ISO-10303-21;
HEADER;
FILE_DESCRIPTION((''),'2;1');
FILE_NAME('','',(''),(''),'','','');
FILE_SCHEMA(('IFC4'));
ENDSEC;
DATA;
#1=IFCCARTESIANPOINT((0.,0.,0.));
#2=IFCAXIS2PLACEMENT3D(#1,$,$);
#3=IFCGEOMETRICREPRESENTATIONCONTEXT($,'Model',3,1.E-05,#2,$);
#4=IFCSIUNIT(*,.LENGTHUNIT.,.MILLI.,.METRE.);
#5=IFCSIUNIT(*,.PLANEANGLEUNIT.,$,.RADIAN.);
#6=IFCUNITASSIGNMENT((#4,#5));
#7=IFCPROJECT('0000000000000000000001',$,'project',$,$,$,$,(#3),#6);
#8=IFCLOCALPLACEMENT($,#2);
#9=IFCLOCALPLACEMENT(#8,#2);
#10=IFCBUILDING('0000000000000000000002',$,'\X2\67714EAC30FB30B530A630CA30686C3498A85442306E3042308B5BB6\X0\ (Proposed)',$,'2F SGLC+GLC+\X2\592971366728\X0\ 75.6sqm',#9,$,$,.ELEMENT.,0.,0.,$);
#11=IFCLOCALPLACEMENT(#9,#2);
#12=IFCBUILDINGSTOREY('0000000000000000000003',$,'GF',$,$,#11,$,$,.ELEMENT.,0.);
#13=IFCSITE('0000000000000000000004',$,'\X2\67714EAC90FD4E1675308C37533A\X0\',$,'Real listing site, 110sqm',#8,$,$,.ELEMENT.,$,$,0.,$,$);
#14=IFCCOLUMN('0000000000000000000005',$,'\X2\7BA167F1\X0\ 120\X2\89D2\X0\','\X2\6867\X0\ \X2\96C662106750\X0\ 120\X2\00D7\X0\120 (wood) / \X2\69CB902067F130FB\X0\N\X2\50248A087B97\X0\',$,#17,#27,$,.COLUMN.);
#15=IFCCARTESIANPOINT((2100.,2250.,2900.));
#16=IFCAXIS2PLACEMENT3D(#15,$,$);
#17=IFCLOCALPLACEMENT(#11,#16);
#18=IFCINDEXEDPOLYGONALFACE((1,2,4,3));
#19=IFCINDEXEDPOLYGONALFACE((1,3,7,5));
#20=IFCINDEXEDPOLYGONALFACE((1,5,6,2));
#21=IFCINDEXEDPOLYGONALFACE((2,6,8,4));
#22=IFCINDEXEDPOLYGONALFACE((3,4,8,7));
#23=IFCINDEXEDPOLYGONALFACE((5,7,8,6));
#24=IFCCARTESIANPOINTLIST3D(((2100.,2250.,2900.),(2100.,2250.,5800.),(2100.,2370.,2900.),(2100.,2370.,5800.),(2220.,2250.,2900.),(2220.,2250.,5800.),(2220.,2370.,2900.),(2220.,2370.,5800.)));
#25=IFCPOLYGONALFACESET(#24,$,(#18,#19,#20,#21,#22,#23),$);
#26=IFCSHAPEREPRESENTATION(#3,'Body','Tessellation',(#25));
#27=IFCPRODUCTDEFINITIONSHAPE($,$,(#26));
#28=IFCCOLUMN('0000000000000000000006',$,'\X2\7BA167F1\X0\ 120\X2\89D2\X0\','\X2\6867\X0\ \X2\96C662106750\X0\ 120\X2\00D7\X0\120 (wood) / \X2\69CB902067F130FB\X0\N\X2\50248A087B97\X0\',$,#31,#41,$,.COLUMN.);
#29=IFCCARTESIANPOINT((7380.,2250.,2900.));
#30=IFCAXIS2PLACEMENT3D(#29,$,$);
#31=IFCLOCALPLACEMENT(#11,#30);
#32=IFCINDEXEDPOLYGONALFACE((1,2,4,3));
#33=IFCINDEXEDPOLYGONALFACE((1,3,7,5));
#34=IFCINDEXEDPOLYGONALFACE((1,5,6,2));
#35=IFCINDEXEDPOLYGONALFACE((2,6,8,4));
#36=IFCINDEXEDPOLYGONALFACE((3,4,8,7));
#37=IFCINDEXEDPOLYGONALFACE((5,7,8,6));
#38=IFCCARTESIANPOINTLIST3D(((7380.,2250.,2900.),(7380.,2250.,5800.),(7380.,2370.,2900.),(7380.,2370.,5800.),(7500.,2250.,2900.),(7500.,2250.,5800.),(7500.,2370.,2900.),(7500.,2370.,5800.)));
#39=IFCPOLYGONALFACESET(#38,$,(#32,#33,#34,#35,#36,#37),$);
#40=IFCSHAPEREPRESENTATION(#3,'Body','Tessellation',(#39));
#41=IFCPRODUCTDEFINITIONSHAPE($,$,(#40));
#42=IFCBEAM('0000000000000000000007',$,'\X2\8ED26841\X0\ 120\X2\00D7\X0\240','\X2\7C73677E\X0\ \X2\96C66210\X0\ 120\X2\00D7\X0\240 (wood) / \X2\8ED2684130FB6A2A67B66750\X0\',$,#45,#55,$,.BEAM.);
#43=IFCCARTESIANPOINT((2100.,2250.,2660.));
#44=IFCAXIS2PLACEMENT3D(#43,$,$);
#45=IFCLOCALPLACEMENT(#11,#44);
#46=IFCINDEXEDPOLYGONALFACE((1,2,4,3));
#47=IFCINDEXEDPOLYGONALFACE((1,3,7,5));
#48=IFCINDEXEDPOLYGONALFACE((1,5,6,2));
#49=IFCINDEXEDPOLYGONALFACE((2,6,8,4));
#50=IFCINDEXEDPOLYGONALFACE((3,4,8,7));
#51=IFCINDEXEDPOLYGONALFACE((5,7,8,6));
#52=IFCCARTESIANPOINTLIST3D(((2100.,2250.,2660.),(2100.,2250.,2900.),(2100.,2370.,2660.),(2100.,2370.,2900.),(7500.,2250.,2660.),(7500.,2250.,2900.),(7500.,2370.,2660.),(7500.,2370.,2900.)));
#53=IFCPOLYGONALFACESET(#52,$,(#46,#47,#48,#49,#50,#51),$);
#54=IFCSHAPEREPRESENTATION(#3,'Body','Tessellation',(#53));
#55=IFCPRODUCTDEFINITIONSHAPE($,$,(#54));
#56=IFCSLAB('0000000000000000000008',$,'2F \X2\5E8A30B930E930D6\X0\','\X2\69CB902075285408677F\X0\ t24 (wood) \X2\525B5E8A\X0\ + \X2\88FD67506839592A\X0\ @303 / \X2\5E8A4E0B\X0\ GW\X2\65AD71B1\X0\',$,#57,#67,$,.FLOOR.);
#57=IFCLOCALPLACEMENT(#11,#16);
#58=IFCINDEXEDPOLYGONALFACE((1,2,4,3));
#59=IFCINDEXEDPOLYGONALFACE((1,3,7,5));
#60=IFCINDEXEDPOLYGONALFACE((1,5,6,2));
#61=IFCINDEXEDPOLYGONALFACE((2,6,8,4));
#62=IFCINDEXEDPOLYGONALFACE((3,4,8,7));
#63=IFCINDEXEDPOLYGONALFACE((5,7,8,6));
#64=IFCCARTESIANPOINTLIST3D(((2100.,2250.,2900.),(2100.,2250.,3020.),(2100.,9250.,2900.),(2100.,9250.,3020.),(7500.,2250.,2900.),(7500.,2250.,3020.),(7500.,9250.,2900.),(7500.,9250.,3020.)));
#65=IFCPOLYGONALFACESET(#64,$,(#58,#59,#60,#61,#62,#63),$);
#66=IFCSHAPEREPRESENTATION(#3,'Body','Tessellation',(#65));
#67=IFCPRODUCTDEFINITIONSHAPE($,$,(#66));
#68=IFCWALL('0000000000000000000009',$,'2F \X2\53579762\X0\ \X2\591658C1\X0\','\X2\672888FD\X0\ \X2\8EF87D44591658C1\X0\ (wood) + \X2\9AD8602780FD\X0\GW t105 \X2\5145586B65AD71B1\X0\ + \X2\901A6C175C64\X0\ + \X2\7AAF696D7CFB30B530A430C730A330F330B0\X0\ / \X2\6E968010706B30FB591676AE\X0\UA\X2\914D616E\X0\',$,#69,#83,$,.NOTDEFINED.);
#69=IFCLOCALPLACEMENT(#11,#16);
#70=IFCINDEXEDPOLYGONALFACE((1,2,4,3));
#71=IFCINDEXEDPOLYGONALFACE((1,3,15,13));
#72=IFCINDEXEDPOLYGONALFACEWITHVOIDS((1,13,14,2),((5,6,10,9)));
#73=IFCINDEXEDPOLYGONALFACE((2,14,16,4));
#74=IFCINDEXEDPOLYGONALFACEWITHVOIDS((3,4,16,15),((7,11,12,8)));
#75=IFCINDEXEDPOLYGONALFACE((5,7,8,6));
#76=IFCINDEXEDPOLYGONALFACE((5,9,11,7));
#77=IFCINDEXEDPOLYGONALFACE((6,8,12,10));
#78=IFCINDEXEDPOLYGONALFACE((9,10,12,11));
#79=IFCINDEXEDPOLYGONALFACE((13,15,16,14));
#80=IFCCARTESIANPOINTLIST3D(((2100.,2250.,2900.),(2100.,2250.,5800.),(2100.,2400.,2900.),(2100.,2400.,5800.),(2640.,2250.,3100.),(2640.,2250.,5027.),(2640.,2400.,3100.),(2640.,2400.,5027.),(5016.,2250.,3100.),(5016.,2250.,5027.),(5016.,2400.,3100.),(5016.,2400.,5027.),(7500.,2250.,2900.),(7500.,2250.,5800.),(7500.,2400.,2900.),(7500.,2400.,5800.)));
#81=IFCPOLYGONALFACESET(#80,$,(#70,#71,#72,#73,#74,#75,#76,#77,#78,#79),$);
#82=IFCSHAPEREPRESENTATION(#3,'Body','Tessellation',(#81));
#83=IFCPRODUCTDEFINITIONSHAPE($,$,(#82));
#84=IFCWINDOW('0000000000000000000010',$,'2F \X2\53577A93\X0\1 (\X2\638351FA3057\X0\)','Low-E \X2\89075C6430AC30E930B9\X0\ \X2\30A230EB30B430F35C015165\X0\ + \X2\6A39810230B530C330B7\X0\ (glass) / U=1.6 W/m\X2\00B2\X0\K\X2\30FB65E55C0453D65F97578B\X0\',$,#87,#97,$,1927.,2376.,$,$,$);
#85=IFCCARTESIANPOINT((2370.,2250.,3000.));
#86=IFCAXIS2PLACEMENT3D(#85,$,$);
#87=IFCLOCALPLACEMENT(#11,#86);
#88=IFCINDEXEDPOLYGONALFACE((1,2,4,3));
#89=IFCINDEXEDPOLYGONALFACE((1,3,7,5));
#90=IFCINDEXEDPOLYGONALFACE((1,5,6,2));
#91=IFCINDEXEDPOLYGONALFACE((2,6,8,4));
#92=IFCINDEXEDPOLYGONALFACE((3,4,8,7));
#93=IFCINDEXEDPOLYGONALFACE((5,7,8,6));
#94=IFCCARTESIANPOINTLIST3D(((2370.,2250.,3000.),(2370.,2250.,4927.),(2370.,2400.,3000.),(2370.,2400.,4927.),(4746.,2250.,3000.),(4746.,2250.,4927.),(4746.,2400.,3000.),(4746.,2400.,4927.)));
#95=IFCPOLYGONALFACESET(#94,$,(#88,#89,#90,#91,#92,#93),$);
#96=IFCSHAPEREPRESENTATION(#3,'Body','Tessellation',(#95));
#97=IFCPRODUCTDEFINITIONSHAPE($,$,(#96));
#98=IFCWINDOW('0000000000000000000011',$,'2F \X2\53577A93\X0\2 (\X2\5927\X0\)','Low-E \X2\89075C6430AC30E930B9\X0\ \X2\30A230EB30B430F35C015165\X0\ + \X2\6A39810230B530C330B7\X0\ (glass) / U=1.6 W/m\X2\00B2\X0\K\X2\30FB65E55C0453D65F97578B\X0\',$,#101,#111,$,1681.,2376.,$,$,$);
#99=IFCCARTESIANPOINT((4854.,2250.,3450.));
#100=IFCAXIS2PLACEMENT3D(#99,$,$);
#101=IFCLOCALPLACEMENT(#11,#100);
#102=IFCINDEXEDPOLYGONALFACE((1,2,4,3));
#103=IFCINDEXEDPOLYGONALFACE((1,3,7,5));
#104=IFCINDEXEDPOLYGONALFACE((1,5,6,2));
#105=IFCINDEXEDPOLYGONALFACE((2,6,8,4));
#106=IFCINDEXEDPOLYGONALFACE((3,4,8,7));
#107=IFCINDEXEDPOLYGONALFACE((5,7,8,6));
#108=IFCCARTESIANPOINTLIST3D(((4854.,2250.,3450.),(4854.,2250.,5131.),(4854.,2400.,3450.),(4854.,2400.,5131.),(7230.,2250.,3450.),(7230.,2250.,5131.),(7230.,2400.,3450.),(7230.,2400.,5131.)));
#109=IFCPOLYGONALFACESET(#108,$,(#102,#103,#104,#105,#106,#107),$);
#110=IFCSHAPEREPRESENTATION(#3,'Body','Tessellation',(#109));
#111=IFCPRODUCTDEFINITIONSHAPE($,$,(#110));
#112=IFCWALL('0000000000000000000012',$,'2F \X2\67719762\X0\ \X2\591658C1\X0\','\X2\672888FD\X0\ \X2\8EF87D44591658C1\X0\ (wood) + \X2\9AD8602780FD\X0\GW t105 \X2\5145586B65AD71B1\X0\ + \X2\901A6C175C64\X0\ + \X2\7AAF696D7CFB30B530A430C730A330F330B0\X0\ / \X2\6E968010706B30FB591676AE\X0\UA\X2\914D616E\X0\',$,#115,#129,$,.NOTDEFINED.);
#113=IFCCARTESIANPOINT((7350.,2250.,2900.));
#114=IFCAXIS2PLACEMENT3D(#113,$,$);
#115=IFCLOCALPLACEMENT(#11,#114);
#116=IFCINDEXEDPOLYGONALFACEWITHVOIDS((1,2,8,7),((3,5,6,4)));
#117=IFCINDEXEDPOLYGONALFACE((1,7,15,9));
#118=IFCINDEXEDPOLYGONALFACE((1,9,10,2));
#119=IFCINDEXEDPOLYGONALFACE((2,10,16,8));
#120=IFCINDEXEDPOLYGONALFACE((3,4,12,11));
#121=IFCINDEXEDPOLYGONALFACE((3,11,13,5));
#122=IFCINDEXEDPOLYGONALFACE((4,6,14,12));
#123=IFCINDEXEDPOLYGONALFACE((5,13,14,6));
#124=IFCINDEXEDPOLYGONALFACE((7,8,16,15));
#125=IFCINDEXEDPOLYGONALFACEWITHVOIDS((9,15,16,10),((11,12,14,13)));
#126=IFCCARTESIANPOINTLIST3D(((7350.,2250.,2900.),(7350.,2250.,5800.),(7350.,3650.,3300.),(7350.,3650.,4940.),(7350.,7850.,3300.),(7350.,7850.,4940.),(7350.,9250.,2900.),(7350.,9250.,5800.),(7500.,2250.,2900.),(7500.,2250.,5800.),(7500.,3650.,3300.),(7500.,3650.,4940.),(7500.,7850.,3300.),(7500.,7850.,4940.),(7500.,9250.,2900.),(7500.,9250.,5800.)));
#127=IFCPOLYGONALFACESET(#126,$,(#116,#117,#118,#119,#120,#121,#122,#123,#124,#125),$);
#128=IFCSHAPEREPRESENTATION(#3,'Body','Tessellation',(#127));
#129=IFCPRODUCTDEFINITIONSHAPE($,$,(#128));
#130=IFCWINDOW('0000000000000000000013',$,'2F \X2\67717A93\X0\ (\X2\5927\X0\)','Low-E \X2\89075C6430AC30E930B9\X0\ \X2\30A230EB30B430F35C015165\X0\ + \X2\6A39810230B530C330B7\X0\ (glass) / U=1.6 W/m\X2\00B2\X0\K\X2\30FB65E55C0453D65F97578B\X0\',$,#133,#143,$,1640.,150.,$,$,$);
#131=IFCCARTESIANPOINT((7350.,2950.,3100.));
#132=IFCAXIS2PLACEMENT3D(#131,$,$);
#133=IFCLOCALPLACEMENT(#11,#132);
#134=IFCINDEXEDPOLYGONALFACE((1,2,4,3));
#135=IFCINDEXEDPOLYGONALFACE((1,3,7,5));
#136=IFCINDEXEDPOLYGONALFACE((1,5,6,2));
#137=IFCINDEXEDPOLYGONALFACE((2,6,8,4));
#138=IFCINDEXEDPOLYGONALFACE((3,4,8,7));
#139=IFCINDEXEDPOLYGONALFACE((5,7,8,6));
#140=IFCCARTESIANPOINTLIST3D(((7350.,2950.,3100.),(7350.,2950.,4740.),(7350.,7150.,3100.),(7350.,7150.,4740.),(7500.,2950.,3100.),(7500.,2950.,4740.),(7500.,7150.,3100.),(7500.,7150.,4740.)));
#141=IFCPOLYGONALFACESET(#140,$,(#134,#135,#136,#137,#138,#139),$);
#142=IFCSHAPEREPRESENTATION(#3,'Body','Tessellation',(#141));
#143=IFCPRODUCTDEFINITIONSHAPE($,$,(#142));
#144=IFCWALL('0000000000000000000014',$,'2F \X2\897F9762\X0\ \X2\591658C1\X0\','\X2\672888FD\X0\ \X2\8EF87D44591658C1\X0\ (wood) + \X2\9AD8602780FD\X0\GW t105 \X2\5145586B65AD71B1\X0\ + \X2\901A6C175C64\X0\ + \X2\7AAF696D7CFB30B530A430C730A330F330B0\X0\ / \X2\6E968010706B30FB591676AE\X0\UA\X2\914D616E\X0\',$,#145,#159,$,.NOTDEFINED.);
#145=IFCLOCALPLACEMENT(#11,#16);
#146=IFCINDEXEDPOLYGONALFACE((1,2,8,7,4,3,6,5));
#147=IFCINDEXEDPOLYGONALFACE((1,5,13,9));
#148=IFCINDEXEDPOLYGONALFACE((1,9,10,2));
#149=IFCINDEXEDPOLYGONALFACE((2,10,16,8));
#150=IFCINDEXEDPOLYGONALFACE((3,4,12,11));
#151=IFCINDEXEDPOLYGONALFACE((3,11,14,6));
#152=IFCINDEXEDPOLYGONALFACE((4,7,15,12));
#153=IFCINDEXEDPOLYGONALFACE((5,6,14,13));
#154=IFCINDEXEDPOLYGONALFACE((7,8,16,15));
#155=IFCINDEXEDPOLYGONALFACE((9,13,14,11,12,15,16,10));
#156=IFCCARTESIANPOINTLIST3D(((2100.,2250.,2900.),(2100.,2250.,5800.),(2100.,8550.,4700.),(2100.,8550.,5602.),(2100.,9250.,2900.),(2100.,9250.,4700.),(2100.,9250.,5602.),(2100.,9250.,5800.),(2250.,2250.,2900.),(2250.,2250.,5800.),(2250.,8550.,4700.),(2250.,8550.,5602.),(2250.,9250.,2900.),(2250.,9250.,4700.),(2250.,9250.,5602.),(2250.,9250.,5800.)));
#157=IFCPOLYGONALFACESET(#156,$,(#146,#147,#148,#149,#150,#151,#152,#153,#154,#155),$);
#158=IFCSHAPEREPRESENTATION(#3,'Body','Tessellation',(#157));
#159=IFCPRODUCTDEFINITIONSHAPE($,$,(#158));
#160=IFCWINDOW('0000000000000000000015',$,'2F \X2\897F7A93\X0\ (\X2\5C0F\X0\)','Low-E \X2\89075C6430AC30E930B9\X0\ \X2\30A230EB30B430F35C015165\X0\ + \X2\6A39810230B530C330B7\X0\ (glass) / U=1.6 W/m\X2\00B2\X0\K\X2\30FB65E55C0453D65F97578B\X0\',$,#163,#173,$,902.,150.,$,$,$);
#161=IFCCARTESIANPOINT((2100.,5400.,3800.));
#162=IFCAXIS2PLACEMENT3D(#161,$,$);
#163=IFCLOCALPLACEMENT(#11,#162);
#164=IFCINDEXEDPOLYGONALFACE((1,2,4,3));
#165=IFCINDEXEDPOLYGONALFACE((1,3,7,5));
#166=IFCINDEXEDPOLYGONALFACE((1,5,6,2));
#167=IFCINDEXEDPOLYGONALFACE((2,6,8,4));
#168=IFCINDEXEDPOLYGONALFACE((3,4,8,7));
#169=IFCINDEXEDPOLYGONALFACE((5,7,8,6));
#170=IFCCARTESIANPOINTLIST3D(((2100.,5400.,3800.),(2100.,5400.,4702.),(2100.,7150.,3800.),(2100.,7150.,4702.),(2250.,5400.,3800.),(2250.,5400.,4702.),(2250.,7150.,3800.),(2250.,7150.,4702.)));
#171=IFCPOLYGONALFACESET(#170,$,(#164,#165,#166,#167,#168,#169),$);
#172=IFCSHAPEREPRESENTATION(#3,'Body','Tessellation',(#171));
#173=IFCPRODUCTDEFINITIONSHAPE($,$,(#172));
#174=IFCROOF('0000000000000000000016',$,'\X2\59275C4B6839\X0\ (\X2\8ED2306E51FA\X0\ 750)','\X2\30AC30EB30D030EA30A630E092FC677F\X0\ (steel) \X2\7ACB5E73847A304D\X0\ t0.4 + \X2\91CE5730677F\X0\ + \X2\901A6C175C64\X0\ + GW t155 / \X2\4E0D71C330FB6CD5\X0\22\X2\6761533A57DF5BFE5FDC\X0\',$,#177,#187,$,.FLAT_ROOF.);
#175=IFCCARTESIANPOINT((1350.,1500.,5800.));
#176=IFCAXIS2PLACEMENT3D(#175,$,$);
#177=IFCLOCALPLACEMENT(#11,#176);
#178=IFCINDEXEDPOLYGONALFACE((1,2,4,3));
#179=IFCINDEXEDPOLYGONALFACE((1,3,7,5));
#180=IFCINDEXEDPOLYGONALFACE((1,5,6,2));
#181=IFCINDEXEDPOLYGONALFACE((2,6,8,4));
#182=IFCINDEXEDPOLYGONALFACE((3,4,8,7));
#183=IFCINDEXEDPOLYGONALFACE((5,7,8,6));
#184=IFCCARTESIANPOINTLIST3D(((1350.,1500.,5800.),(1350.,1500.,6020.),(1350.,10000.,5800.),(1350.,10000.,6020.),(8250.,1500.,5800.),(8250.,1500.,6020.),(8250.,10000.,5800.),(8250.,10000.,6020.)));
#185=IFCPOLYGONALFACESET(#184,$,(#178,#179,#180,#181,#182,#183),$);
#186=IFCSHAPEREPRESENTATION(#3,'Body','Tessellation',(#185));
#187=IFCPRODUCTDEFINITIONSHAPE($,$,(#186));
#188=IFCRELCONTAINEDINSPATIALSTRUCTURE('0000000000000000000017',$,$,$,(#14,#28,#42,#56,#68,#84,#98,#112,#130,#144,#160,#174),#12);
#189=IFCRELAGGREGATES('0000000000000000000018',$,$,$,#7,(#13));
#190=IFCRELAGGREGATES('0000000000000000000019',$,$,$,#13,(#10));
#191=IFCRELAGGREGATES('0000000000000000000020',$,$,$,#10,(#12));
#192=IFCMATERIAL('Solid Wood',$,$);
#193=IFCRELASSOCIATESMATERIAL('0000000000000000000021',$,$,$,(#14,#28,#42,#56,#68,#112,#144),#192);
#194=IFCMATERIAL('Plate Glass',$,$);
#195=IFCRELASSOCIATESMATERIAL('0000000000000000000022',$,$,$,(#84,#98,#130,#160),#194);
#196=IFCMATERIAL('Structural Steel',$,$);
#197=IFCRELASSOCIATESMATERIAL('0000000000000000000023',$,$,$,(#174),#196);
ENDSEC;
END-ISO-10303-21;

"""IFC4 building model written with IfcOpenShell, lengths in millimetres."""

from ifc_helpers import new_model, si_unit, frame, frame_2d, origin, place, context, project, spatial, rectangle, extrude, material, element, fill, save


model = new_model("IFC4")

# Units and contexts
model_context = context("Model", 3, precision=1e-05, world=origin())
ifc_project = project(units=[si_unit("LENGTHUNIT", "METRE", prefix="MILLI"), si_unit("PLANEANGLEUNIT", "RADIAN")], contexts=[model_context])

# Site, building, storey
site_placement = place(None, origin())
site = spatial("IfcSite", under=ifc_project, at=site_placement, Name="東京都世田谷区", ObjectType="Real listing site, 110sqm", CompositionType="ELEMENT", RefElevation=0.0)
building_placement = place(site_placement, origin())
building = spatial("IfcBuilding", under=site, at=building_placement, Name="東京・サウナと水風呂のある家 (Proposed)", ObjectType="2F SGLC+GLC+天然木 75.6sqm", CompositionType="ELEMENT", ElevationOfRefHeight=0.0, ElevationOfTerrain=0.0)
storey_placement = place(building_placement, origin())
storey = spatial("IfcBuildingStorey", under=building, at=storey_placement, Name="GF", CompositionType="ELEMENT", Elevation=0.0)

# Columns
ifc_material_1 = material(Name="Solid Wood")
column_1_placement = place(storey_placement, frame((2100.0, 2250.0, 2900.0)))
element("IfcColumn", 1, at=column_1_placement, inside=storey, material=ifc_material_1, Name="管柱 120角", Description="桧 集成材 120×120 (wood) / 構造柱・N値計算", PredefinedType="COLUMN", context=model_context, shape_type="SweptSolid", body=[
    extrude(rectangle(XDim=120.0, YDim=120.0, at=frame_2d((60.0, 60.0))), frame((2100.0, 2250.0, 2900.0)), (0.0, 0.0, 1.0), 2900.0),
])
column_2_placement = place(storey_placement, frame((7380.0, 2250.0, 2900.0)))
element("IfcColumn", 2, at=column_2_placement, inside=storey, material=ifc_material_1, Name="管柱 120角", Description="桧 集成材 120×120 (wood) / 構造柱・N値計算", PredefinedType="COLUMN", context=model_context, shape_type="SweptSolid", body=[
    extrude(rectangle(XDim=120.0, YDim=120.0, at=frame_2d((60.0, 60.0))), frame((7380.0, 2250.0, 2900.0)), (0.0, 0.0, 1.0), 2900.0),
])

# Beam
beam_1_placement = place(storey_placement, frame((2100.0, 2250.0, 2660.0)))
element("IfcBeam", 3, at=beam_1_placement, inside=storey, material=ifc_material_1, Name="軒桁 120×240", Description="米松 集成 120×240 (wood) / 軒桁・横架材", PredefinedType="BEAM", context=model_context, shape_type="SweptSolid", body=[
    extrude(rectangle(XDim=5400.0, YDim=120.0, at=frame_2d((2700.0, 60.0))), frame((2100.0, 2250.0, 2660.0)), (0.0, 0.0, 1.0), 240.0),
])

# Slab
slab_placement = place(storey_placement, frame((2100.0, 2250.0, 2900.0)))
element("IfcSlab", 4, at=slab_placement, inside=storey, material=ifc_material_1, Name="2F 床スラブ", Description="構造用合板 t24 (wood) 剛床 + 製材根太 @303 / 床下 GW断熱", PredefinedType="FLOOR", context=model_context, shape_type="SweptSolid", body=[
    extrude(rectangle(XDim=5400.0, YDim=7000.0, at=frame_2d((2700.0, 3500.0))), frame((2100.0, 2250.0, 2900.0)), (0.0, 0.0, 1.0), 120.0),
])

# Wall, openings, windows
wall_1_placement = place(storey_placement, frame((2100.0, 2250.0, 2900.0)))
wall_1 = element("IfcWall", 5, at=wall_1_placement, inside=storey, material=ifc_material_1, Name="2F 南面 外壁", Description="木製 軸組外壁 (wood) + 高性能GW t105 充填断熱 + 通気層 + 窯業系サイディング / 準耐火・外皮UA配慮", PredefinedType="NOTDEFINED", context=model_context, shape_type="SweptSolid", body=[
    extrude(rectangle(XDim=5400.0, YDim=150.0, at=frame_2d((2700.0, 75.0))), frame((2100.0, 2250.0, 2900.0)), (0.0, 0.0, 1.0), 2900.0),
])
opening_1_placement = place(storey_placement, frame((2370.0, 2250.0, 3000.0)))
opening_1 = element("IfcOpeningElement", 6, at=opening_1_placement, cuts=wall_1, PredefinedType="NOTDEFINED", context=model_context, shape_type="SweptSolid", body=[
    extrude(rectangle(XDim=2376.0, YDim=150.0, at=frame_2d((1188.0, 75.0))), frame((2370.0, 2250.0, 3000.0)), (0.0, 0.0, 1.0), 1927.0),
])
opening_2_placement = place(storey_placement, frame((4854.0, 2250.0, 3450.0)))
opening_2 = element("IfcOpeningElement", 7, at=opening_2_placement, cuts=wall_1, PredefinedType="NOTDEFINED", context=model_context, shape_type="SweptSolid", body=[
    extrude(rectangle(XDim=2376.0, YDim=150.0, at=frame_2d((1188.0, 75.0))), frame((4854.0, 2250.0, 3450.0)), (0.0, 0.0, 1.0), 1681.0),
])
ifc_material_2 = material(Name="Plate Glass")
window_1_placement = place(storey_placement, frame((2370.0, 2250.0, 3000.0)))
window_1 = element("IfcWindow", 8, at=window_1_placement, inside=storey, material=ifc_material_2, Name="2F 南窓1 (掃出し)", Description="Low-E 複層ガラス アルゴン封入 + 樹脂サッシ (glass) / U=1.6 W/m²K・日射取得型", OverallHeight=1927.0, OverallWidth=2376.0, context=model_context, shape_type="SweptSolid", body=[
    extrude(rectangle(XDim=2376.0, YDim=150.0, at=frame_2d((1188.0, 75.0))), frame((2370.0, 2250.0, 3000.0)), (0.0, 0.0, 1.0), 1927.0),
])
fill(opening_1, window_1)
window_2_placement = place(storey_placement, frame((4854.0, 2250.0, 3450.0)))
window_2 = element("IfcWindow", 9, at=window_2_placement, inside=storey, material=ifc_material_2, Name="2F 南窓2 (大)", Description="Low-E 複層ガラス アルゴン封入 + 樹脂サッシ (glass) / U=1.6 W/m²K・日射取得型", OverallHeight=1681.0, OverallWidth=2376.0, context=model_context, shape_type="SweptSolid", body=[
    extrude(rectangle(XDim=2376.0, YDim=150.0, at=frame_2d((1188.0, 75.0))), frame((4854.0, 2250.0, 3450.0)), (0.0, 0.0, 1.0), 1681.0),
])
fill(opening_2, window_2)

# Walls, openings, windows
wall_2_placement = place(storey_placement, frame((7350.0, 2250.0, 2900.0)))
wall_2 = element("IfcWall", 10, at=wall_2_placement, inside=storey, material=ifc_material_1, Name="2F 東面 外壁", Description="木製 軸組外壁 (wood) + 高性能GW t105 充填断熱 + 通気層 + 窯業系サイディング / 準耐火・外皮UA配慮", PredefinedType="NOTDEFINED", context=model_context, shape_type="SweptSolid", body=[
    extrude(rectangle(XDim=150.0, YDim=7000.0, at=frame_2d((75.0, 3500.0))), frame((7350.0, 2250.0, 2900.0)), (0.0, 0.0, 1.0), 2900.0),
])
opening_3_placement = place(storey_placement, frame((7350.0, 2950.0, 3100.0)))
opening_3 = element("IfcOpeningElement", 11, at=opening_3_placement, cuts=wall_2, PredefinedType="NOTDEFINED", context=model_context, shape_type="SweptSolid", body=[
    extrude(rectangle(XDim=150.0, YDim=4200.0, at=frame_2d((75.0, 2100.0))), frame((7350.0, 2950.0, 3100.0)), (0.0, 0.0, 1.0), 1640.0),
])
window_3_placement = place(storey_placement, frame((7350.0, 2950.0, 3100.0)))
window_3 = element("IfcWindow", 12, at=window_3_placement, inside=storey, material=ifc_material_2, Name="2F 東窓 (大)", Description="Low-E 複層ガラス アルゴン封入 + 樹脂サッシ (glass) / U=1.6 W/m²K・日射取得型", OverallHeight=1640.0, OverallWidth=150.0, context=model_context, shape_type="SweptSolid", body=[
    extrude(rectangle(XDim=150.0, YDim=4200.0, at=frame_2d((75.0, 2100.0))), frame((7350.0, 2950.0, 3100.0)), (0.0, 0.0, 1.0), 1640.0),
])
fill(opening_3, window_3)
wall_3_placement = place(storey_placement, frame((2100.0, 2250.0, 2900.0)))
wall_3 = element("IfcWall", 13, at=wall_3_placement, inside=storey, material=ifc_material_1, Name="2F 西面 外壁", Description="木製 軸組外壁 (wood) + 高性能GW t105 充填断熱 + 通気層 + 窯業系サイディング / 準耐火・外皮UA配慮", PredefinedType="NOTDEFINED", context=model_context, shape_type="SweptSolid", body=[
    extrude(rectangle(XDim=150.0, YDim=7000.0, at=frame_2d((75.0, 3500.0))), frame((2100.0, 2250.0, 2900.0)), (0.0, 0.0, 1.0), 2900.0),
])
opening_4_placement = place(storey_placement, frame((2100.0, 5400.0, 3800.0)))
opening_4 = element("IfcOpeningElement", 14, at=opening_4_placement, cuts=wall_3, PredefinedType="NOTDEFINED", context=model_context, shape_type="SweptSolid", body=[
    extrude(rectangle(XDim=150.0, YDim=1750.0, at=frame_2d((75.0, 875.0))), frame((2100.0, 5400.0, 3800.0)), (0.0, 0.0, 1.0), 902.0),
])
window_4_placement = place(storey_placement, frame((2100.0, 5400.0, 3800.0)))
window_4 = element("IfcWindow", 15, at=window_4_placement, inside=storey, material=ifc_material_2, Name="2F 西窓 (小)", Description="Low-E 複層ガラス アルゴン封入 + 樹脂サッシ (glass) / U=1.6 W/m²K・日射取得型", OverallHeight=902.0, OverallWidth=150.0, context=model_context, shape_type="SweptSolid", body=[
    extrude(rectangle(XDim=150.0, YDim=1750.0, at=frame_2d((75.0, 875.0))), frame((2100.0, 5400.0, 3800.0)), (0.0, 0.0, 1.0), 902.0),
])
fill(opening_4, window_4)

# Roof
ifc_material_3 = material(Name="Structural Steel")
roof_placement = place(storey_placement, frame((1350.0, 1500.0, 5800.0)))
element("IfcRoof", 16, at=roof_placement, inside=storey, material=ifc_material_3, Name="大屋根 (軒の出 750)", Description="ガルバリウム鋼板 (steel) 立平葺き t0.4 + 野地板 + 通気層 + GW t155 / 不燃・法22条区域対応", PredefinedType="FLAT_ROOF", context=model_context, shape_type="SweptSolid", body=[
    extrude(rectangle(XDim=6900.0, YDim=8500.0, at=frame_2d((3450.0, 4250.0))), frame((1350.0, 1500.0, 5800.0)), (0.0, 0.0, 1.0), 220.0),
])

save(model, "model.ifc")
